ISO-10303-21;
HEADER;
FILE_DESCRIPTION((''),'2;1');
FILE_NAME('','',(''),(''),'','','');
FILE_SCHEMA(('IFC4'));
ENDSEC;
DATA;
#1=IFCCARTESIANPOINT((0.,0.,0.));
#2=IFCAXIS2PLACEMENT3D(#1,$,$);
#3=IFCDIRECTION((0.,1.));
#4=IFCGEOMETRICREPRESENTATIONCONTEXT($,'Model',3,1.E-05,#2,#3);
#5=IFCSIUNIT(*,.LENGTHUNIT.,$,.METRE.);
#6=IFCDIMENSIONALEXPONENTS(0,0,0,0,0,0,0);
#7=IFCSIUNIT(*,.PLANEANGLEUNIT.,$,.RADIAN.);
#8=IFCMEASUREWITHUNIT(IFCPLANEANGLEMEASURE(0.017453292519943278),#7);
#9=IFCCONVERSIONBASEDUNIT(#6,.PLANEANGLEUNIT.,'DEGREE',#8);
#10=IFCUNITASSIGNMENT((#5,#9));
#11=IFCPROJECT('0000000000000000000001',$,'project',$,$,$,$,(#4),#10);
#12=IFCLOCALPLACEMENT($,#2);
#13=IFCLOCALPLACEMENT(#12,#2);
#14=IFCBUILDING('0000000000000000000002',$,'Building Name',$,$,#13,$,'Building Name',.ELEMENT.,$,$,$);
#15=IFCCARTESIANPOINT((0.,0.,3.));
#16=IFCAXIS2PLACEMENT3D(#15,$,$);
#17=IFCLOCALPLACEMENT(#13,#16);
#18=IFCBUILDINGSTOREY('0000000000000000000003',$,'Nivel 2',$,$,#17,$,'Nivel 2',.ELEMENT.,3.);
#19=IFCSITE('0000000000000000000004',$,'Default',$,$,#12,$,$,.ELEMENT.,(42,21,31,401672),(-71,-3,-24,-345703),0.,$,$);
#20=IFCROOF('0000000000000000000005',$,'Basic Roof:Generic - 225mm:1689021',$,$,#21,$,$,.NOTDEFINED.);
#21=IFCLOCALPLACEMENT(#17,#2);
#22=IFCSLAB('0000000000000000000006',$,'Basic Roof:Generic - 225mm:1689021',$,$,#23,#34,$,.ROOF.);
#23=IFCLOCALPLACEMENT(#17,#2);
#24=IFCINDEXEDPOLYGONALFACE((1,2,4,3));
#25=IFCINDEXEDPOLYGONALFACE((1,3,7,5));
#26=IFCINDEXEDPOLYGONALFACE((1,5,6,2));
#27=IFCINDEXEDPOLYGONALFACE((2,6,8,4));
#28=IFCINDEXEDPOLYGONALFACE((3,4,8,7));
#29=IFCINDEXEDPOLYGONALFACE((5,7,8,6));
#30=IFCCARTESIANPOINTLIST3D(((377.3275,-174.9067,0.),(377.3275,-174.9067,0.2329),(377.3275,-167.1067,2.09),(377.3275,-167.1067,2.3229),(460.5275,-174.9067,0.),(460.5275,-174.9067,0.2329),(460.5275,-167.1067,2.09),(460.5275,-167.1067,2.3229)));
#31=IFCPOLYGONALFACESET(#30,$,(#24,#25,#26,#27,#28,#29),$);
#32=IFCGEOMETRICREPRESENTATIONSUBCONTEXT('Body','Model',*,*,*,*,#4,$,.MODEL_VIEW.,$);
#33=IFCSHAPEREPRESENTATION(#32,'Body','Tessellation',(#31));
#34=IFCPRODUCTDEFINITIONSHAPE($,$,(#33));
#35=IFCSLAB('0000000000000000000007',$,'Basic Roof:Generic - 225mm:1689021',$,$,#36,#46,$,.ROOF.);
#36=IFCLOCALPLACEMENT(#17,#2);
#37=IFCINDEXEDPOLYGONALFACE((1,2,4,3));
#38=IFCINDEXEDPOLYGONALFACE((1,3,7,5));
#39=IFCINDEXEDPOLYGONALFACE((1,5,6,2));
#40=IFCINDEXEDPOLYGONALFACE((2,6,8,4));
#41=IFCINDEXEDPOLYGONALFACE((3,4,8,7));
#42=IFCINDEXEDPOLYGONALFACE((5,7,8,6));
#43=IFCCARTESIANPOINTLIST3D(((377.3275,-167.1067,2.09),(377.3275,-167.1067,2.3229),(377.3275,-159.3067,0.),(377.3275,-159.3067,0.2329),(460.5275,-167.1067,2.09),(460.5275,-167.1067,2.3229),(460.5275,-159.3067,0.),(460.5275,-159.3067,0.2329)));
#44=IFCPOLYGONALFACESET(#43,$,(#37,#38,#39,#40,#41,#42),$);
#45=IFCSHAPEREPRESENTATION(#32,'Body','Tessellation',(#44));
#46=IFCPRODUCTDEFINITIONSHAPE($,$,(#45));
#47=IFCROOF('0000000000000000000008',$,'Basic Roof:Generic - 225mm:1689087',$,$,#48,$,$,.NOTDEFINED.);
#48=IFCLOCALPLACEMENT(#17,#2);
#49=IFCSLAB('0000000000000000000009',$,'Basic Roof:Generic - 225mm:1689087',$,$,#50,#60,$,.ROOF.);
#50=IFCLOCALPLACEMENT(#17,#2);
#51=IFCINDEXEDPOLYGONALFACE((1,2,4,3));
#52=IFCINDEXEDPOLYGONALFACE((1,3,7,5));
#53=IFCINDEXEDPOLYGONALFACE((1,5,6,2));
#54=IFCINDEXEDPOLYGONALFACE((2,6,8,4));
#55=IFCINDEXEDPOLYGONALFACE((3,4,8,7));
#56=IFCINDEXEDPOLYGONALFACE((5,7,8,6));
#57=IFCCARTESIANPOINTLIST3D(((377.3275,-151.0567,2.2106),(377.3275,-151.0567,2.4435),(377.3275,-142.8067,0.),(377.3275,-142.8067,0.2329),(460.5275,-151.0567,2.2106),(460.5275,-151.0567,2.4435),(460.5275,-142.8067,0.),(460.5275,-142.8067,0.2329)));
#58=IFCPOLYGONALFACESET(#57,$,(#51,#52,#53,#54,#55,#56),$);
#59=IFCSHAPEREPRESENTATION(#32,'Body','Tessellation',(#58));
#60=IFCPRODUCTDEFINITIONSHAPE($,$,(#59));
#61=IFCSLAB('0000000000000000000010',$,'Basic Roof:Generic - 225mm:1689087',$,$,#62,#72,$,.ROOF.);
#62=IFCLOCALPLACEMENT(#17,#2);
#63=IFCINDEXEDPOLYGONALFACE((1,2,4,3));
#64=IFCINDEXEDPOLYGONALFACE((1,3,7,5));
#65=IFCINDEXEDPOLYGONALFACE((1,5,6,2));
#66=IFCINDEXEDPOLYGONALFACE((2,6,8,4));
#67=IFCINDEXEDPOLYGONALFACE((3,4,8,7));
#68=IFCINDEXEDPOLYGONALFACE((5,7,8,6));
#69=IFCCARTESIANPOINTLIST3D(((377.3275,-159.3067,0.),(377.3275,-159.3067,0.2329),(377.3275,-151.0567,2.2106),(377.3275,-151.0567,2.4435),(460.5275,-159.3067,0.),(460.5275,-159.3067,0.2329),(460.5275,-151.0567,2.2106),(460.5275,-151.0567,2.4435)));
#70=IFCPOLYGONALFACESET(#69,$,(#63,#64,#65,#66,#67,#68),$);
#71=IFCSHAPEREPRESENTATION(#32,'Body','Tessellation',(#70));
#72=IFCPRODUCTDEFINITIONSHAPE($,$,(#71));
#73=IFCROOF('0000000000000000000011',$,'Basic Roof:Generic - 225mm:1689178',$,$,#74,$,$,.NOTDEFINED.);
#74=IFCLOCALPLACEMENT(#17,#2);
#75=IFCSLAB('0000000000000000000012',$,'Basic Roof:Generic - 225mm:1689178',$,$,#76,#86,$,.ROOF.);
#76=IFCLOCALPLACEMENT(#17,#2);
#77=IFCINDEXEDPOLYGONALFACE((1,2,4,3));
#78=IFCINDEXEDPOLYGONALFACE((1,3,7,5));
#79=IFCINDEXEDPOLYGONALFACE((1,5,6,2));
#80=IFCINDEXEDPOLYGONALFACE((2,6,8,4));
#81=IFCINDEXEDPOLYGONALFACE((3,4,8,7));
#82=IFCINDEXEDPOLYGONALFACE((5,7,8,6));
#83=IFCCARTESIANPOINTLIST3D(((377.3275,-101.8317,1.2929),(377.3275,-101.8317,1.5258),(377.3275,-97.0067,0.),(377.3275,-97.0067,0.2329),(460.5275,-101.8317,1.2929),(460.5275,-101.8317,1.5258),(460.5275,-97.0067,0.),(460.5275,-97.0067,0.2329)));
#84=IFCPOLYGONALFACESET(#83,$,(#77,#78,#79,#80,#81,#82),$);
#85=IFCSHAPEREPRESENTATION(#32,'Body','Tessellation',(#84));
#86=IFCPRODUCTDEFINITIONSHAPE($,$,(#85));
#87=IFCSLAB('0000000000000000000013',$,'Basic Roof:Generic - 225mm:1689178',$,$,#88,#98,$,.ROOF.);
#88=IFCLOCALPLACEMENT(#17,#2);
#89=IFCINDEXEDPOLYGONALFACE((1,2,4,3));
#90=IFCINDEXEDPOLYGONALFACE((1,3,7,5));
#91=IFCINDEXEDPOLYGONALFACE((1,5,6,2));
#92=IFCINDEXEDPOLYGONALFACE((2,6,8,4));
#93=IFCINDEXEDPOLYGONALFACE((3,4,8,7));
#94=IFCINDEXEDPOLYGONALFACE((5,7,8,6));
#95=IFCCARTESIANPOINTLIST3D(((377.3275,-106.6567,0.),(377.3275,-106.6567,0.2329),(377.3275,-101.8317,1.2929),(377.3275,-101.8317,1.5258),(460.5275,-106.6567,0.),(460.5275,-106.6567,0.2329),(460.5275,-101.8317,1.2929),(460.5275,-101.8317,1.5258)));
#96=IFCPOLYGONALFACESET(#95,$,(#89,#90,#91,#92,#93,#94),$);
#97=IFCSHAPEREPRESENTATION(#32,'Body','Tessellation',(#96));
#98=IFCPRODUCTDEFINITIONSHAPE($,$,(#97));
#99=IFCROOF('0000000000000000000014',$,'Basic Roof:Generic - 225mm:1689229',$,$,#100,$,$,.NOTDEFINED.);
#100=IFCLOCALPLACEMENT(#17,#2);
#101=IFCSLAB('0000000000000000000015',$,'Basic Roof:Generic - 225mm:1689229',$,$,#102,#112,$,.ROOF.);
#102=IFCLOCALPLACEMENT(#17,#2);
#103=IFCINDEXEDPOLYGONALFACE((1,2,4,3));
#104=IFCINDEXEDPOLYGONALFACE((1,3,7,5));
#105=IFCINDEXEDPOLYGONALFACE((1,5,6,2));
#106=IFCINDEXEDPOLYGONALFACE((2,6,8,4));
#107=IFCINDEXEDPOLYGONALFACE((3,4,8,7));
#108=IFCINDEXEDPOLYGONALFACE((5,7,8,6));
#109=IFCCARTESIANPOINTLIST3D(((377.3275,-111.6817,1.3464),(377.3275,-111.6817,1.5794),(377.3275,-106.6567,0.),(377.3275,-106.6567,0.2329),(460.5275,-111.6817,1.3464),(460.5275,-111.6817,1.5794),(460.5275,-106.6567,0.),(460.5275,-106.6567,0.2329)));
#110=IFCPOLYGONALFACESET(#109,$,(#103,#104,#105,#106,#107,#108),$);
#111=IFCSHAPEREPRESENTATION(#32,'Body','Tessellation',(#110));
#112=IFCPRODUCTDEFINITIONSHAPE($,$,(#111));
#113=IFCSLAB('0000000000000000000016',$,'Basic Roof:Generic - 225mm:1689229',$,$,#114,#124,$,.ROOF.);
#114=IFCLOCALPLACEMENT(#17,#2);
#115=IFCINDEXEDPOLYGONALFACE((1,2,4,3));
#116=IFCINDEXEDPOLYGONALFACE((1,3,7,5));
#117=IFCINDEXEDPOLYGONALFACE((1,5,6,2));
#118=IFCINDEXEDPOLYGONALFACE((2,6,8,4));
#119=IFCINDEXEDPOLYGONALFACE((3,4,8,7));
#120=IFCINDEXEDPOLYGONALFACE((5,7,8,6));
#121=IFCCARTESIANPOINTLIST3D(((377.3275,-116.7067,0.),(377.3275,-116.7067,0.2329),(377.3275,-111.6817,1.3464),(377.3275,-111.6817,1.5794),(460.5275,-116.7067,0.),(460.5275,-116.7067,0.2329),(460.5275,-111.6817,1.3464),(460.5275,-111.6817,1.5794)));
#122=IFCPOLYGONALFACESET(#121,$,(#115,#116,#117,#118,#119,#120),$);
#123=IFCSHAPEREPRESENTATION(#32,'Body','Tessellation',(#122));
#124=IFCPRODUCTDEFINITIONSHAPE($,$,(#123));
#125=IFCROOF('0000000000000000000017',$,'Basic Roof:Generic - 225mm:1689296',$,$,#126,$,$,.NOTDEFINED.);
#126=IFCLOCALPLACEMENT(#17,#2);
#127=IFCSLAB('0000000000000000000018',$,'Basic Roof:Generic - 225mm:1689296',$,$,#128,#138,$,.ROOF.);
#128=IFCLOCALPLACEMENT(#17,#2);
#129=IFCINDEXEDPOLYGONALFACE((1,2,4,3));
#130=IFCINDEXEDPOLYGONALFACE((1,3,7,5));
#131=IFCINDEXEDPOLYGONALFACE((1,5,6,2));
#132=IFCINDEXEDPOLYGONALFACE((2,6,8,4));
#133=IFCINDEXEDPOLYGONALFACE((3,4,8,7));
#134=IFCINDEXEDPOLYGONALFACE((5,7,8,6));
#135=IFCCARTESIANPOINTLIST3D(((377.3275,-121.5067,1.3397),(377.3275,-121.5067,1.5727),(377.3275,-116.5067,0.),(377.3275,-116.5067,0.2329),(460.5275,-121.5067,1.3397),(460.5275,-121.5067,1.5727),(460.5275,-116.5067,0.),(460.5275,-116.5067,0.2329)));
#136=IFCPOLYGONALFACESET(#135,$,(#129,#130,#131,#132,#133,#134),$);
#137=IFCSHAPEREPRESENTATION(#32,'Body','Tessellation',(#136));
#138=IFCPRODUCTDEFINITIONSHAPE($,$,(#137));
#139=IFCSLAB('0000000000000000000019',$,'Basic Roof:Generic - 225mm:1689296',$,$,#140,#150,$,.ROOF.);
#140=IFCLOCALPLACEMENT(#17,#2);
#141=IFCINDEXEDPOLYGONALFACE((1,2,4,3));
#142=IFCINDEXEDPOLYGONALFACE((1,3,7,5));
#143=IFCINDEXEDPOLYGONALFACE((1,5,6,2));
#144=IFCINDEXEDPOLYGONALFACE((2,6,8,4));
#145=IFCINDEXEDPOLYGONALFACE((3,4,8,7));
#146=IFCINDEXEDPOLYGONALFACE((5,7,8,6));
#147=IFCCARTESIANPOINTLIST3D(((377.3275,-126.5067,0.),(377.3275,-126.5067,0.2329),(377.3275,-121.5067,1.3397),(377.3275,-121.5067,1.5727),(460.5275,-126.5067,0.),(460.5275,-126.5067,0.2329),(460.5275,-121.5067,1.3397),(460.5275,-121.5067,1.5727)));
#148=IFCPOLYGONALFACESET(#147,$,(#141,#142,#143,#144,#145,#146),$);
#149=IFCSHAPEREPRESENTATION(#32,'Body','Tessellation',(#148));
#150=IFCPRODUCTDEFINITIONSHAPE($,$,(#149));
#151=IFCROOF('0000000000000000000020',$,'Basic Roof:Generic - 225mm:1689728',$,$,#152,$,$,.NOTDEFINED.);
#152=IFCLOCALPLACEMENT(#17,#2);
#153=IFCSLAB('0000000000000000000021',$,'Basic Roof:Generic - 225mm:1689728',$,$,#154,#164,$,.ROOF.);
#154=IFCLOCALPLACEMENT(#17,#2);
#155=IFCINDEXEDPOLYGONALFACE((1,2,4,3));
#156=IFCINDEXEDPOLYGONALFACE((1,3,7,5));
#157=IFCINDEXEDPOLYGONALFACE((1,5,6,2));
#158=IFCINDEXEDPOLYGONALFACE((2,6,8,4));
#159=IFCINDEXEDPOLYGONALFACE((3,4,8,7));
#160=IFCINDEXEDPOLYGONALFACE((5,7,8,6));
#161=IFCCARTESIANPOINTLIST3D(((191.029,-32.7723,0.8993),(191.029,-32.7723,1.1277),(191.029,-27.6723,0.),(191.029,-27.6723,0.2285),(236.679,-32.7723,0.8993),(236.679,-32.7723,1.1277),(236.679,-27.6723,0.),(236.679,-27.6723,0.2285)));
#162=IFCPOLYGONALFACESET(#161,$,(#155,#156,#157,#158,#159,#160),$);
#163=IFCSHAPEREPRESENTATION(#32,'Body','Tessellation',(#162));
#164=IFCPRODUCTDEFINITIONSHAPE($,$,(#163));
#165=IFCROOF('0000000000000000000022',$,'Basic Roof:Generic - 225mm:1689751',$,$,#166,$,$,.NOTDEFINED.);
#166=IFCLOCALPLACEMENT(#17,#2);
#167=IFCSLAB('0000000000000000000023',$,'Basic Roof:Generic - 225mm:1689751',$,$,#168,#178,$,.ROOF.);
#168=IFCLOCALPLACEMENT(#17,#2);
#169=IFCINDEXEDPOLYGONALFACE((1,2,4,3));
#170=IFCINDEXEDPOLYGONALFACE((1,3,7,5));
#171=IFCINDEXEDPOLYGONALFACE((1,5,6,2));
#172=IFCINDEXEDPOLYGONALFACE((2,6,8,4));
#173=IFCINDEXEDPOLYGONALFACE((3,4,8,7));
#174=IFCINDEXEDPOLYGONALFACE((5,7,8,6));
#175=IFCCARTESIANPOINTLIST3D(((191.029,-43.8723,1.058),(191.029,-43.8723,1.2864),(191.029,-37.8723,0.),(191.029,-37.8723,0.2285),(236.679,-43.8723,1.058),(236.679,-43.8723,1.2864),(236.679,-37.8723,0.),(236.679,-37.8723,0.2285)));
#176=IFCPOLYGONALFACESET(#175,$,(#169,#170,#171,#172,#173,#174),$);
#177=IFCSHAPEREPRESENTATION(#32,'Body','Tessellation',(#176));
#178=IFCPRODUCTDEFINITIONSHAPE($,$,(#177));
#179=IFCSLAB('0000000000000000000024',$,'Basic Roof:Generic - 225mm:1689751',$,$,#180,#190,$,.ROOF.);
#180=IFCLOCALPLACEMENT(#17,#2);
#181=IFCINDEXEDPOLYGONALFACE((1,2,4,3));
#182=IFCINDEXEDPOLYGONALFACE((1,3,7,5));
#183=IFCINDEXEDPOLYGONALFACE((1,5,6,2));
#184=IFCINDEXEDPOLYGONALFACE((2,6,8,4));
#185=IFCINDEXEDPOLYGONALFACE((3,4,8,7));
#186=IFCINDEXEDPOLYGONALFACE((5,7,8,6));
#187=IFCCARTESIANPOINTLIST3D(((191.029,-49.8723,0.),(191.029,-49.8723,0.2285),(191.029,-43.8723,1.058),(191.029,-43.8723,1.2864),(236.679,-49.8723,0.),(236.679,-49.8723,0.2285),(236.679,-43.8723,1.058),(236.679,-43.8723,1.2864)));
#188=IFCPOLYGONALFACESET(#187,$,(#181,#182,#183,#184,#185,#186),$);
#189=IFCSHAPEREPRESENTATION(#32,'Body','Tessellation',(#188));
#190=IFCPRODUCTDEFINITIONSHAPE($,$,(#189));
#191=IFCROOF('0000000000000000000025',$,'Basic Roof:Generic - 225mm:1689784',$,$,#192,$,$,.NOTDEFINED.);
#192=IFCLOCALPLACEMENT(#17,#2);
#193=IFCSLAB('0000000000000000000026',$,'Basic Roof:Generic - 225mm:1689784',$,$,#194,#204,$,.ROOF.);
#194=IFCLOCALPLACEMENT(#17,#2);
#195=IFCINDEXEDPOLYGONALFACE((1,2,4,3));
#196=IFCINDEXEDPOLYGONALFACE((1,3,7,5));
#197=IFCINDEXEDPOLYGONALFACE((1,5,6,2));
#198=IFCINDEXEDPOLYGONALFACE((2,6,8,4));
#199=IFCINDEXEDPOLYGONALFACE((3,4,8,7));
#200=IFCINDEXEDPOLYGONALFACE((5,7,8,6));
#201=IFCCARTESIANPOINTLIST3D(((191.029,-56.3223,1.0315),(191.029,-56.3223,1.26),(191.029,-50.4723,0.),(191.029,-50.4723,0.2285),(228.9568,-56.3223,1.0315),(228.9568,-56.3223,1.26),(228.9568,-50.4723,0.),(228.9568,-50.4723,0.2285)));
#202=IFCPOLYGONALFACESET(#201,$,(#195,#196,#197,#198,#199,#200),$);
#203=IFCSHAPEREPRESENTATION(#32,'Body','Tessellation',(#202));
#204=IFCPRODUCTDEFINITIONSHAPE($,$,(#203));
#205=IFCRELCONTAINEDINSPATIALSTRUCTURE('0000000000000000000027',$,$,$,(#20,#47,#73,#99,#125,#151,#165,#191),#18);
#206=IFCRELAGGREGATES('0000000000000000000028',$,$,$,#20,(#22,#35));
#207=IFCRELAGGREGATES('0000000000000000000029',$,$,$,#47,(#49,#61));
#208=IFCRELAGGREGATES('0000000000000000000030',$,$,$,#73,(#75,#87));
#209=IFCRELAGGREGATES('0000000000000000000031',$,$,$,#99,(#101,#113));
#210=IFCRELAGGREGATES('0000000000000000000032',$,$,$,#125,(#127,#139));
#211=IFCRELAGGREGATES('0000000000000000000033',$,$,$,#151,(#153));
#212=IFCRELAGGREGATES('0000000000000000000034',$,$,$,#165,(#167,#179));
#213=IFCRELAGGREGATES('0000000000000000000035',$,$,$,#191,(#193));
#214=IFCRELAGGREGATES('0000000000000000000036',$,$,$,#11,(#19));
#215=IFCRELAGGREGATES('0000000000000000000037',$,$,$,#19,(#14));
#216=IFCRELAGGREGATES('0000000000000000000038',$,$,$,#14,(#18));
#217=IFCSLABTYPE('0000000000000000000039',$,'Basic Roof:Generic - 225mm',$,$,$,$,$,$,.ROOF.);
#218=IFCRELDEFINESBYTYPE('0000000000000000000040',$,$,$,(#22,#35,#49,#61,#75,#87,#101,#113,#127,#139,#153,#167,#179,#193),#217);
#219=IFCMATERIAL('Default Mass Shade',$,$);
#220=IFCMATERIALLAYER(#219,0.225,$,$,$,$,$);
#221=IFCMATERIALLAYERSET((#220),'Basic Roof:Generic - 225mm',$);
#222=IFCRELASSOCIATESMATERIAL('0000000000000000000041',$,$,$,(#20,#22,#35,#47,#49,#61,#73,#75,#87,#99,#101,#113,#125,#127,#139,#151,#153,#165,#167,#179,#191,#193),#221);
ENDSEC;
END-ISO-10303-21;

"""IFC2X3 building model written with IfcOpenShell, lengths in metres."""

from ifc_helpers import new_model, entity, si_unit, converted_unit, direction, frame, frame_2d, origin, place, context, subcontext, project, spatial, rectangle, extrude, material, layer, layer_set, type_object, element, aggregate, save


model = new_model("IFC2X3")

# Units and contexts
model_context = context("Model", 3, precision=1e-05, world=origin(), true_north=direction((0.0, 1.0)))
body_context = subcontext(model_context, "Body", "Model", "MODEL_VIEW")
ifc_project = project(units=[si_unit("LENGTHUNIT", "METRE"), converted_unit("PLANEANGLEUNIT", "DEGREE", entity("IfcPlaneAngleMeasure", 0.017453292519943278), si_unit("PLANEANGLEUNIT", "RADIAN"), dimensions=[0, 0, 0, 0, 0, 0, 0])], contexts=[model_context])

# Site, building, storey
site_placement = place(None, origin())
site = spatial("IfcSite", under=ifc_project, at=site_placement, Name="Default", CompositionType="ELEMENT", RefLatitude=(42, 21, 31, 401672), RefLongitude=(-71, -3, -24, -345703), RefElevation=0.0)
building_placement = place(site_placement, origin())
building = spatial("IfcBuilding", under=site, at=building_placement, Name="Building Name", LongName="Building Name", CompositionType="ELEMENT")
storey_placement = place(building_placement, frame((0.0, 0.0, 3.0)))
storey = spatial("IfcBuildingStorey", under=building, at=storey_placement, Name="Nivel 2", LongName="Nivel 2", CompositionType="ELEMENT", Elevation=3.0)

# Roofs, slabs
ifc_material = material(Name="Default Mass Shade")
ifc_layer = layer(ifc_material, 0.225)
ifc_layer_set = layer_set([ifc_layer], Name="Basic Roof:Generic - 225mm")
roof_1_placement = place(storey_placement, frame((377.3275, -174.9067, 0.0)))
roof_1 = element("IfcRoof", 1, at=roof_1_placement, inside=storey, material=ifc_layer_set, Name="Basic Roof:Generic - 225mm:1689021", ShapeType="NOTDEFINED")
slab_type = type_object("IfcSlabType", Name="Basic Roof:Generic - 225mm", PredefinedType="ROOF")
slab_1_placement = place(roof_1_placement, origin())
slab_1 = element("IfcSlab", 2, at=slab_1_placement, type_object=slab_type, material=ifc_layer_set, Name="Basic Roof:Generic - 225mm:1689021", PredefinedType="ROOF", context=body_context, shape_type="SweptSolid", body=[
    extrude(rectangle(XDim=8.0752, YDim=83.2, at=frame_2d((0.0, 0.0), x_axis=(0.0, 1.0))), frame((41.6, 3.9, 1.045), z_axis=(0.0, -0.258819, 0.965926), x_axis=(1.0, 0.0, 0.0)), (0.0, 0.258819, 0.965926), 0.2329),
])
slab_2_placement = place(roof_1_placement, origin())
slab_2 = element("IfcSlab", 3, at=slab_2_placement, type_object=slab_type, material=ifc_layer_set, Name="Basic Roof:Generic - 225mm:1689021", PredefinedType="ROOF", context=body_context, shape_type="SweptSolid", body=[
    extrude(rectangle(XDim=83.2, YDim=8.0752, at=frame_2d((0.0, 0.0), x_axis=(1.0, 0.0))), frame((41.6, 11.7, 1.045), z_axis=(0.0, 0.258819, 0.965926), x_axis=(1.0, 0.0, 0.0)), (0.0, -0.258819, 0.965926), 0.2329),
])
aggregate(roof_1, [slab_1, slab_2])
roof_2_placement = place(storey_placement, frame((377.3275, -159.3067, 0.0)))
roof_2 = element("IfcRoof", 4, at=roof_2_placement, inside=storey, material=ifc_layer_set, Name="Basic Roof:Generic - 225mm:1689087", ShapeType="NOTDEFINED")
slab_3_placement = place(roof_2_placement, origin())
slab_3 = element("IfcSlab", 5, at=slab_3_placement, type_object=slab_type, material=ifc_layer_set, Name="Basic Roof:Generic - 225mm:1689087", PredefinedType="ROOF", context=body_context, shape_type="SweptSolid", body=[
    extrude(rectangle(XDim=8.541, YDim=83.2, at=frame_2d((0.0, 0.0), x_axis=(0.0, -1.0))), frame((41.6, 12.375, 1.1053), z_axis=(0.0, 0.258819, 0.965926), x_axis=(1.0, 0.0, 0.0)), (0.0, -0.258819, 0.965926), 0.2329),
])
slab_4_placement = place(roof_2_placement, origin())
slab_4 = element("IfcSlab", 6, at=slab_4_placement, type_object=slab_type, material=ifc_layer_set, Name="Basic Roof:Generic - 225mm:1689087", PredefinedType="ROOF", context=body_context, shape_type="SweptSolid", body=[
    extrude(rectangle(XDim=83.2, YDim=8.541, at=frame_2d((0.0, 0.0), x_axis=(-1.0, 0.0))), frame((41.6, 4.125, 1.1053), z_axis=(0.0, -0.258819, 0.965926), x_axis=(1.0, 0.0, 0.0)), (0.0, 0.258819, 0.965926), 0.2329),
])
aggregate(roof_2, [slab_3, slab_4])
roof_3_placement = place(storey_placement, frame((377.3275, -106.6567, 0.0)))
roof_3 = element("IfcRoof", 7, at=roof_3_placement, inside=storey, material=ifc_layer_set, Name="Basic Roof:Generic - 225mm:1689178", ShapeType="NOTDEFINED")
slab_5_placement = place(roof_3_placement, origin())
slab_5 = element("IfcSlab", 8, at=slab_5_placement, type_object=slab_type, material=ifc_layer_set, Name="Basic Roof:Generic - 225mm:1689178", PredefinedType="ROOF", context=body_context, shape_type="SweptSolid", body=[
    extrude(rectangle(XDim=4.9952, YDim=83.2, at=frame_2d((0.0, 0.0), x_axis=(0.0, -1.0))), frame((41.6, 7.2375, 0.6464), z_axis=(0.0, 0.258819, 0.965926), x_axis=(1.0, 0.0, 0.0)), (0.0, -0.258819, 0.965926), 0.2329),
])
slab_6_placement = place(roof_3_placement, origin())
slab_6 = element("IfcSlab", 9, at=slab_6_placement, type_object=slab_type, material=ifc_layer_set, Name="Basic Roof:Generic - 225mm:1689178", PredefinedType="ROOF", context=body_context, shape_type="SweptSolid", body=[
    extrude(rectangle(XDim=83.2, YDim=4.9952, at=frame_2d((0.0, 0.0), x_axis=(-1.0, 0.0))), frame((41.6, 2.4125, 0.6464), z_axis=(0.0, -0.258819, 0.965926), x_axis=(1.0, 0.0, 0.0)), (0.0, 0.258819, 0.965926), 0.2329),
])
aggregate(roof_3, [slab_5, slab_6])
roof_4_placement = place(storey_placement, frame((377.3275, -116.7067, 0.0)))
roof_4 = element("IfcRoof", 10, at=roof_4_placement, inside=storey, material=ifc_layer_set, Name="Basic Roof:Generic - 225mm:1689229", ShapeType="NOTDEFINED")
slab_7_placement = place(roof_4_placement, origin())
slab_7 = element("IfcSlab", 11, at=slab_7_placement, type_object=slab_type, material=ifc_layer_set, Name="Basic Roof:Generic - 225mm:1689229", PredefinedType="ROOF", context=body_context, shape_type="SweptSolid", body=[
    extrude(rectangle(XDim=83.2, YDim=5.2023, at=frame_2d((0.0, 0.0), x_axis=(1.0, 0.0))), frame((41.6, 7.5375, 0.6732), z_axis=(0.0, 0.258819, 0.965926), x_axis=(1.0, 0.0, 0.0)), (0.0, -0.258819, 0.965926), 0.2329),
])
slab_8_placement = place(roof_4_placement, origin())
slab_8 = element("IfcSlab", 12, at=slab_8_placement, type_object=slab_type, material=ifc_layer_set, Name="Basic Roof:Generic - 225mm:1689229", PredefinedType="ROOF", context=body_context, shape_type="SweptSolid", body=[
    extrude(rectangle(XDim=5.2023, YDim=83.2, at=frame_2d((0.0, 0.0), x_axis=(0.0, 1.0))), frame((41.6, 2.5125, 0.6732), z_axis=(0.0, -0.258819, 0.965926), x_axis=(1.0, 0.0, 0.0)), (0.0, 0.258819, 0.965926), 0.2329),
])
aggregate(roof_4, [slab_7, slab_8])
roof_5_placement = place(storey_placement, frame((377.3275, -126.5067, 0.0)))
roof_5 = element("IfcRoof", 13, at=roof_5_placement, inside=storey, material=ifc_layer_set, Name="Basic Roof:Generic - 225mm:1689296", ShapeType="NOTDEFINED")
slab_9_placement = place(roof_5_placement, origin())
slab_9 = element("IfcSlab", 14, at=slab_9_placement, type_object=slab_type, material=ifc_layer_set, Name="Basic Roof:Generic - 225mm:1689296", PredefinedType="ROOF", context=body_context, shape_type="SweptSolid", body=[
    extrude(rectangle(XDim=83.2, YDim=5.1764, at=frame_2d((0.0, 0.0), x_axis=(1.0, 0.0))), frame((41.6, 7.5, 0.6699), z_axis=(0.0, 0.258819, 0.965926), x_axis=(1.0, 0.0, 0.0)), (0.0, -0.258819, 0.965926), 0.2329),
])
slab_10_placement = place(roof_5_placement, origin())
slab_10 = element("IfcSlab", 15, at=slab_10_placement, type_object=slab_type, material=ifc_layer_set, Name="Basic Roof:Generic - 225mm:1689296", PredefinedType="ROOF", context=body_context, shape_type="SweptSolid", body=[
    extrude(rectangle(XDim=5.1764, YDim=83.2, at=frame_2d((0.0, 0.0), x_axis=(0.0, 1.0))), frame((41.6, 2.5, 0.6699), z_axis=(0.0, -0.258819, 0.965926), x_axis=(1.0, 0.0, 0.0)), (0.0, 0.258819, 0.965926), 0.2329),
])
aggregate(roof_5, [slab_9, slab_10])

# Roof, slab
roof_6_placement = place(storey_placement, frame((191.029, -37.8723, 0.0)))
roof_6 = element("IfcRoof", 16, at=roof_6_placement, inside=storey, material=ifc_layer_set, Name="Basic Roof:Generic - 225mm:1689728", ShapeType="NOTDEFINED")
slab_11_placement = place(roof_6_placement, origin())
slab_11 = element("IfcSlab", 17, at=slab_11_placement, type_object=slab_type, material=ifc_layer_set, Name="Basic Roof:Generic - 225mm:1689728", PredefinedType="ROOF", context=body_context, shape_type="SweptSolid", body=[
    extrude(rectangle(XDim=45.65, YDim=5.1787, at=frame_2d((0.0, 0.0), x_axis=(1.0, 0.0))), frame((22.825, 7.65, 0.4496), z_axis=(0.0, 0.173648, 0.984808), x_axis=(1.0, 0.0, 0.0)), (0.0, -0.173648, 0.984808), 0.2285),
])
aggregate(roof_6, [slab_11])

# Roofs, slabs
roof_7_placement = place(storey_placement, frame((191.029, -49.8723, 0.0)))
roof_7 = element("IfcRoof", 18, at=roof_7_placement, inside=storey, material=ifc_layer_set, Name="Basic Roof:Generic - 225mm:1689751", ShapeType="NOTDEFINED")
slab_12_placement = place(roof_7_placement, origin())
slab_12 = element("IfcSlab", 19, at=slab_12_placement, type_object=slab_type, material=ifc_layer_set, Name="Basic Roof:Generic - 225mm:1689751", PredefinedType="ROOF", context=body_context, shape_type="SweptSolid", body=[
    extrude(rectangle(XDim=45.65, YDim=6.0926, at=frame_2d((0.0, 0.0), x_axis=(1.0, 0.0))), frame((22.825, 9.0, 0.529), z_axis=(0.0, 0.173648, 0.984808), x_axis=(1.0, 0.0, 0.0)), (0.0, -0.173648, 0.984808), 0.2285),
])
slab_13_placement = place(roof_7_placement, origin())
slab_13 = element("IfcSlab", 20, at=slab_13_placement, type_object=slab_type, material=ifc_layer_set, Name="Basic Roof:Generic - 225mm:1689751", PredefinedType="ROOF", context=body_context, shape_type="SweptSolid", body=[
    extrude(rectangle(XDim=6.0926, YDim=45.65, at=frame_2d((0.0, 0.0), x_axis=(0.0, 1.0))), frame((22.825, 3.0, 0.529), z_axis=(0.0, -0.173648, 0.984808), x_axis=(1.0, 0.0, 0.0)), (0.0, 0.173648, 0.984808), 0.2285),
])
aggregate(roof_7, [slab_12, slab_13])
roof_8_placement = place(storey_placement, frame((191.029, -62.1723, 0.0)))
roof_8 = element("IfcRoof", 21, at=roof_8_placement, inside=storey, material=ifc_layer_set, Name="Basic Roof:Generic - 225mm:1689784", ShapeType="NOTDEFINED")
slab_14_placement = place(roof_8_placement, origin())
slab_14 = element("IfcSlab", 22, at=slab_14_placement, type_object=slab_type, material=ifc_layer_set, Name="Basic Roof:Generic - 225mm:1689784", PredefinedType="ROOF", context=body_context, shape_type="SweptSolid", body=[
    extrude(rectangle(XDim=37.9278, YDim=5.9402, at=frame_2d((0.0, 0.0), x_axis=(1.0, 0.0))), frame((18.9639, 8.775, 0.5158), z_axis=(0.0, 0.173648, 0.984808), x_axis=(1.0, 0.0, 0.0)), (0.0, -0.173648, 0.984808), 0.2285),
])
aggregate(roof_8, [slab_14])

save(model, "model.ifc")
